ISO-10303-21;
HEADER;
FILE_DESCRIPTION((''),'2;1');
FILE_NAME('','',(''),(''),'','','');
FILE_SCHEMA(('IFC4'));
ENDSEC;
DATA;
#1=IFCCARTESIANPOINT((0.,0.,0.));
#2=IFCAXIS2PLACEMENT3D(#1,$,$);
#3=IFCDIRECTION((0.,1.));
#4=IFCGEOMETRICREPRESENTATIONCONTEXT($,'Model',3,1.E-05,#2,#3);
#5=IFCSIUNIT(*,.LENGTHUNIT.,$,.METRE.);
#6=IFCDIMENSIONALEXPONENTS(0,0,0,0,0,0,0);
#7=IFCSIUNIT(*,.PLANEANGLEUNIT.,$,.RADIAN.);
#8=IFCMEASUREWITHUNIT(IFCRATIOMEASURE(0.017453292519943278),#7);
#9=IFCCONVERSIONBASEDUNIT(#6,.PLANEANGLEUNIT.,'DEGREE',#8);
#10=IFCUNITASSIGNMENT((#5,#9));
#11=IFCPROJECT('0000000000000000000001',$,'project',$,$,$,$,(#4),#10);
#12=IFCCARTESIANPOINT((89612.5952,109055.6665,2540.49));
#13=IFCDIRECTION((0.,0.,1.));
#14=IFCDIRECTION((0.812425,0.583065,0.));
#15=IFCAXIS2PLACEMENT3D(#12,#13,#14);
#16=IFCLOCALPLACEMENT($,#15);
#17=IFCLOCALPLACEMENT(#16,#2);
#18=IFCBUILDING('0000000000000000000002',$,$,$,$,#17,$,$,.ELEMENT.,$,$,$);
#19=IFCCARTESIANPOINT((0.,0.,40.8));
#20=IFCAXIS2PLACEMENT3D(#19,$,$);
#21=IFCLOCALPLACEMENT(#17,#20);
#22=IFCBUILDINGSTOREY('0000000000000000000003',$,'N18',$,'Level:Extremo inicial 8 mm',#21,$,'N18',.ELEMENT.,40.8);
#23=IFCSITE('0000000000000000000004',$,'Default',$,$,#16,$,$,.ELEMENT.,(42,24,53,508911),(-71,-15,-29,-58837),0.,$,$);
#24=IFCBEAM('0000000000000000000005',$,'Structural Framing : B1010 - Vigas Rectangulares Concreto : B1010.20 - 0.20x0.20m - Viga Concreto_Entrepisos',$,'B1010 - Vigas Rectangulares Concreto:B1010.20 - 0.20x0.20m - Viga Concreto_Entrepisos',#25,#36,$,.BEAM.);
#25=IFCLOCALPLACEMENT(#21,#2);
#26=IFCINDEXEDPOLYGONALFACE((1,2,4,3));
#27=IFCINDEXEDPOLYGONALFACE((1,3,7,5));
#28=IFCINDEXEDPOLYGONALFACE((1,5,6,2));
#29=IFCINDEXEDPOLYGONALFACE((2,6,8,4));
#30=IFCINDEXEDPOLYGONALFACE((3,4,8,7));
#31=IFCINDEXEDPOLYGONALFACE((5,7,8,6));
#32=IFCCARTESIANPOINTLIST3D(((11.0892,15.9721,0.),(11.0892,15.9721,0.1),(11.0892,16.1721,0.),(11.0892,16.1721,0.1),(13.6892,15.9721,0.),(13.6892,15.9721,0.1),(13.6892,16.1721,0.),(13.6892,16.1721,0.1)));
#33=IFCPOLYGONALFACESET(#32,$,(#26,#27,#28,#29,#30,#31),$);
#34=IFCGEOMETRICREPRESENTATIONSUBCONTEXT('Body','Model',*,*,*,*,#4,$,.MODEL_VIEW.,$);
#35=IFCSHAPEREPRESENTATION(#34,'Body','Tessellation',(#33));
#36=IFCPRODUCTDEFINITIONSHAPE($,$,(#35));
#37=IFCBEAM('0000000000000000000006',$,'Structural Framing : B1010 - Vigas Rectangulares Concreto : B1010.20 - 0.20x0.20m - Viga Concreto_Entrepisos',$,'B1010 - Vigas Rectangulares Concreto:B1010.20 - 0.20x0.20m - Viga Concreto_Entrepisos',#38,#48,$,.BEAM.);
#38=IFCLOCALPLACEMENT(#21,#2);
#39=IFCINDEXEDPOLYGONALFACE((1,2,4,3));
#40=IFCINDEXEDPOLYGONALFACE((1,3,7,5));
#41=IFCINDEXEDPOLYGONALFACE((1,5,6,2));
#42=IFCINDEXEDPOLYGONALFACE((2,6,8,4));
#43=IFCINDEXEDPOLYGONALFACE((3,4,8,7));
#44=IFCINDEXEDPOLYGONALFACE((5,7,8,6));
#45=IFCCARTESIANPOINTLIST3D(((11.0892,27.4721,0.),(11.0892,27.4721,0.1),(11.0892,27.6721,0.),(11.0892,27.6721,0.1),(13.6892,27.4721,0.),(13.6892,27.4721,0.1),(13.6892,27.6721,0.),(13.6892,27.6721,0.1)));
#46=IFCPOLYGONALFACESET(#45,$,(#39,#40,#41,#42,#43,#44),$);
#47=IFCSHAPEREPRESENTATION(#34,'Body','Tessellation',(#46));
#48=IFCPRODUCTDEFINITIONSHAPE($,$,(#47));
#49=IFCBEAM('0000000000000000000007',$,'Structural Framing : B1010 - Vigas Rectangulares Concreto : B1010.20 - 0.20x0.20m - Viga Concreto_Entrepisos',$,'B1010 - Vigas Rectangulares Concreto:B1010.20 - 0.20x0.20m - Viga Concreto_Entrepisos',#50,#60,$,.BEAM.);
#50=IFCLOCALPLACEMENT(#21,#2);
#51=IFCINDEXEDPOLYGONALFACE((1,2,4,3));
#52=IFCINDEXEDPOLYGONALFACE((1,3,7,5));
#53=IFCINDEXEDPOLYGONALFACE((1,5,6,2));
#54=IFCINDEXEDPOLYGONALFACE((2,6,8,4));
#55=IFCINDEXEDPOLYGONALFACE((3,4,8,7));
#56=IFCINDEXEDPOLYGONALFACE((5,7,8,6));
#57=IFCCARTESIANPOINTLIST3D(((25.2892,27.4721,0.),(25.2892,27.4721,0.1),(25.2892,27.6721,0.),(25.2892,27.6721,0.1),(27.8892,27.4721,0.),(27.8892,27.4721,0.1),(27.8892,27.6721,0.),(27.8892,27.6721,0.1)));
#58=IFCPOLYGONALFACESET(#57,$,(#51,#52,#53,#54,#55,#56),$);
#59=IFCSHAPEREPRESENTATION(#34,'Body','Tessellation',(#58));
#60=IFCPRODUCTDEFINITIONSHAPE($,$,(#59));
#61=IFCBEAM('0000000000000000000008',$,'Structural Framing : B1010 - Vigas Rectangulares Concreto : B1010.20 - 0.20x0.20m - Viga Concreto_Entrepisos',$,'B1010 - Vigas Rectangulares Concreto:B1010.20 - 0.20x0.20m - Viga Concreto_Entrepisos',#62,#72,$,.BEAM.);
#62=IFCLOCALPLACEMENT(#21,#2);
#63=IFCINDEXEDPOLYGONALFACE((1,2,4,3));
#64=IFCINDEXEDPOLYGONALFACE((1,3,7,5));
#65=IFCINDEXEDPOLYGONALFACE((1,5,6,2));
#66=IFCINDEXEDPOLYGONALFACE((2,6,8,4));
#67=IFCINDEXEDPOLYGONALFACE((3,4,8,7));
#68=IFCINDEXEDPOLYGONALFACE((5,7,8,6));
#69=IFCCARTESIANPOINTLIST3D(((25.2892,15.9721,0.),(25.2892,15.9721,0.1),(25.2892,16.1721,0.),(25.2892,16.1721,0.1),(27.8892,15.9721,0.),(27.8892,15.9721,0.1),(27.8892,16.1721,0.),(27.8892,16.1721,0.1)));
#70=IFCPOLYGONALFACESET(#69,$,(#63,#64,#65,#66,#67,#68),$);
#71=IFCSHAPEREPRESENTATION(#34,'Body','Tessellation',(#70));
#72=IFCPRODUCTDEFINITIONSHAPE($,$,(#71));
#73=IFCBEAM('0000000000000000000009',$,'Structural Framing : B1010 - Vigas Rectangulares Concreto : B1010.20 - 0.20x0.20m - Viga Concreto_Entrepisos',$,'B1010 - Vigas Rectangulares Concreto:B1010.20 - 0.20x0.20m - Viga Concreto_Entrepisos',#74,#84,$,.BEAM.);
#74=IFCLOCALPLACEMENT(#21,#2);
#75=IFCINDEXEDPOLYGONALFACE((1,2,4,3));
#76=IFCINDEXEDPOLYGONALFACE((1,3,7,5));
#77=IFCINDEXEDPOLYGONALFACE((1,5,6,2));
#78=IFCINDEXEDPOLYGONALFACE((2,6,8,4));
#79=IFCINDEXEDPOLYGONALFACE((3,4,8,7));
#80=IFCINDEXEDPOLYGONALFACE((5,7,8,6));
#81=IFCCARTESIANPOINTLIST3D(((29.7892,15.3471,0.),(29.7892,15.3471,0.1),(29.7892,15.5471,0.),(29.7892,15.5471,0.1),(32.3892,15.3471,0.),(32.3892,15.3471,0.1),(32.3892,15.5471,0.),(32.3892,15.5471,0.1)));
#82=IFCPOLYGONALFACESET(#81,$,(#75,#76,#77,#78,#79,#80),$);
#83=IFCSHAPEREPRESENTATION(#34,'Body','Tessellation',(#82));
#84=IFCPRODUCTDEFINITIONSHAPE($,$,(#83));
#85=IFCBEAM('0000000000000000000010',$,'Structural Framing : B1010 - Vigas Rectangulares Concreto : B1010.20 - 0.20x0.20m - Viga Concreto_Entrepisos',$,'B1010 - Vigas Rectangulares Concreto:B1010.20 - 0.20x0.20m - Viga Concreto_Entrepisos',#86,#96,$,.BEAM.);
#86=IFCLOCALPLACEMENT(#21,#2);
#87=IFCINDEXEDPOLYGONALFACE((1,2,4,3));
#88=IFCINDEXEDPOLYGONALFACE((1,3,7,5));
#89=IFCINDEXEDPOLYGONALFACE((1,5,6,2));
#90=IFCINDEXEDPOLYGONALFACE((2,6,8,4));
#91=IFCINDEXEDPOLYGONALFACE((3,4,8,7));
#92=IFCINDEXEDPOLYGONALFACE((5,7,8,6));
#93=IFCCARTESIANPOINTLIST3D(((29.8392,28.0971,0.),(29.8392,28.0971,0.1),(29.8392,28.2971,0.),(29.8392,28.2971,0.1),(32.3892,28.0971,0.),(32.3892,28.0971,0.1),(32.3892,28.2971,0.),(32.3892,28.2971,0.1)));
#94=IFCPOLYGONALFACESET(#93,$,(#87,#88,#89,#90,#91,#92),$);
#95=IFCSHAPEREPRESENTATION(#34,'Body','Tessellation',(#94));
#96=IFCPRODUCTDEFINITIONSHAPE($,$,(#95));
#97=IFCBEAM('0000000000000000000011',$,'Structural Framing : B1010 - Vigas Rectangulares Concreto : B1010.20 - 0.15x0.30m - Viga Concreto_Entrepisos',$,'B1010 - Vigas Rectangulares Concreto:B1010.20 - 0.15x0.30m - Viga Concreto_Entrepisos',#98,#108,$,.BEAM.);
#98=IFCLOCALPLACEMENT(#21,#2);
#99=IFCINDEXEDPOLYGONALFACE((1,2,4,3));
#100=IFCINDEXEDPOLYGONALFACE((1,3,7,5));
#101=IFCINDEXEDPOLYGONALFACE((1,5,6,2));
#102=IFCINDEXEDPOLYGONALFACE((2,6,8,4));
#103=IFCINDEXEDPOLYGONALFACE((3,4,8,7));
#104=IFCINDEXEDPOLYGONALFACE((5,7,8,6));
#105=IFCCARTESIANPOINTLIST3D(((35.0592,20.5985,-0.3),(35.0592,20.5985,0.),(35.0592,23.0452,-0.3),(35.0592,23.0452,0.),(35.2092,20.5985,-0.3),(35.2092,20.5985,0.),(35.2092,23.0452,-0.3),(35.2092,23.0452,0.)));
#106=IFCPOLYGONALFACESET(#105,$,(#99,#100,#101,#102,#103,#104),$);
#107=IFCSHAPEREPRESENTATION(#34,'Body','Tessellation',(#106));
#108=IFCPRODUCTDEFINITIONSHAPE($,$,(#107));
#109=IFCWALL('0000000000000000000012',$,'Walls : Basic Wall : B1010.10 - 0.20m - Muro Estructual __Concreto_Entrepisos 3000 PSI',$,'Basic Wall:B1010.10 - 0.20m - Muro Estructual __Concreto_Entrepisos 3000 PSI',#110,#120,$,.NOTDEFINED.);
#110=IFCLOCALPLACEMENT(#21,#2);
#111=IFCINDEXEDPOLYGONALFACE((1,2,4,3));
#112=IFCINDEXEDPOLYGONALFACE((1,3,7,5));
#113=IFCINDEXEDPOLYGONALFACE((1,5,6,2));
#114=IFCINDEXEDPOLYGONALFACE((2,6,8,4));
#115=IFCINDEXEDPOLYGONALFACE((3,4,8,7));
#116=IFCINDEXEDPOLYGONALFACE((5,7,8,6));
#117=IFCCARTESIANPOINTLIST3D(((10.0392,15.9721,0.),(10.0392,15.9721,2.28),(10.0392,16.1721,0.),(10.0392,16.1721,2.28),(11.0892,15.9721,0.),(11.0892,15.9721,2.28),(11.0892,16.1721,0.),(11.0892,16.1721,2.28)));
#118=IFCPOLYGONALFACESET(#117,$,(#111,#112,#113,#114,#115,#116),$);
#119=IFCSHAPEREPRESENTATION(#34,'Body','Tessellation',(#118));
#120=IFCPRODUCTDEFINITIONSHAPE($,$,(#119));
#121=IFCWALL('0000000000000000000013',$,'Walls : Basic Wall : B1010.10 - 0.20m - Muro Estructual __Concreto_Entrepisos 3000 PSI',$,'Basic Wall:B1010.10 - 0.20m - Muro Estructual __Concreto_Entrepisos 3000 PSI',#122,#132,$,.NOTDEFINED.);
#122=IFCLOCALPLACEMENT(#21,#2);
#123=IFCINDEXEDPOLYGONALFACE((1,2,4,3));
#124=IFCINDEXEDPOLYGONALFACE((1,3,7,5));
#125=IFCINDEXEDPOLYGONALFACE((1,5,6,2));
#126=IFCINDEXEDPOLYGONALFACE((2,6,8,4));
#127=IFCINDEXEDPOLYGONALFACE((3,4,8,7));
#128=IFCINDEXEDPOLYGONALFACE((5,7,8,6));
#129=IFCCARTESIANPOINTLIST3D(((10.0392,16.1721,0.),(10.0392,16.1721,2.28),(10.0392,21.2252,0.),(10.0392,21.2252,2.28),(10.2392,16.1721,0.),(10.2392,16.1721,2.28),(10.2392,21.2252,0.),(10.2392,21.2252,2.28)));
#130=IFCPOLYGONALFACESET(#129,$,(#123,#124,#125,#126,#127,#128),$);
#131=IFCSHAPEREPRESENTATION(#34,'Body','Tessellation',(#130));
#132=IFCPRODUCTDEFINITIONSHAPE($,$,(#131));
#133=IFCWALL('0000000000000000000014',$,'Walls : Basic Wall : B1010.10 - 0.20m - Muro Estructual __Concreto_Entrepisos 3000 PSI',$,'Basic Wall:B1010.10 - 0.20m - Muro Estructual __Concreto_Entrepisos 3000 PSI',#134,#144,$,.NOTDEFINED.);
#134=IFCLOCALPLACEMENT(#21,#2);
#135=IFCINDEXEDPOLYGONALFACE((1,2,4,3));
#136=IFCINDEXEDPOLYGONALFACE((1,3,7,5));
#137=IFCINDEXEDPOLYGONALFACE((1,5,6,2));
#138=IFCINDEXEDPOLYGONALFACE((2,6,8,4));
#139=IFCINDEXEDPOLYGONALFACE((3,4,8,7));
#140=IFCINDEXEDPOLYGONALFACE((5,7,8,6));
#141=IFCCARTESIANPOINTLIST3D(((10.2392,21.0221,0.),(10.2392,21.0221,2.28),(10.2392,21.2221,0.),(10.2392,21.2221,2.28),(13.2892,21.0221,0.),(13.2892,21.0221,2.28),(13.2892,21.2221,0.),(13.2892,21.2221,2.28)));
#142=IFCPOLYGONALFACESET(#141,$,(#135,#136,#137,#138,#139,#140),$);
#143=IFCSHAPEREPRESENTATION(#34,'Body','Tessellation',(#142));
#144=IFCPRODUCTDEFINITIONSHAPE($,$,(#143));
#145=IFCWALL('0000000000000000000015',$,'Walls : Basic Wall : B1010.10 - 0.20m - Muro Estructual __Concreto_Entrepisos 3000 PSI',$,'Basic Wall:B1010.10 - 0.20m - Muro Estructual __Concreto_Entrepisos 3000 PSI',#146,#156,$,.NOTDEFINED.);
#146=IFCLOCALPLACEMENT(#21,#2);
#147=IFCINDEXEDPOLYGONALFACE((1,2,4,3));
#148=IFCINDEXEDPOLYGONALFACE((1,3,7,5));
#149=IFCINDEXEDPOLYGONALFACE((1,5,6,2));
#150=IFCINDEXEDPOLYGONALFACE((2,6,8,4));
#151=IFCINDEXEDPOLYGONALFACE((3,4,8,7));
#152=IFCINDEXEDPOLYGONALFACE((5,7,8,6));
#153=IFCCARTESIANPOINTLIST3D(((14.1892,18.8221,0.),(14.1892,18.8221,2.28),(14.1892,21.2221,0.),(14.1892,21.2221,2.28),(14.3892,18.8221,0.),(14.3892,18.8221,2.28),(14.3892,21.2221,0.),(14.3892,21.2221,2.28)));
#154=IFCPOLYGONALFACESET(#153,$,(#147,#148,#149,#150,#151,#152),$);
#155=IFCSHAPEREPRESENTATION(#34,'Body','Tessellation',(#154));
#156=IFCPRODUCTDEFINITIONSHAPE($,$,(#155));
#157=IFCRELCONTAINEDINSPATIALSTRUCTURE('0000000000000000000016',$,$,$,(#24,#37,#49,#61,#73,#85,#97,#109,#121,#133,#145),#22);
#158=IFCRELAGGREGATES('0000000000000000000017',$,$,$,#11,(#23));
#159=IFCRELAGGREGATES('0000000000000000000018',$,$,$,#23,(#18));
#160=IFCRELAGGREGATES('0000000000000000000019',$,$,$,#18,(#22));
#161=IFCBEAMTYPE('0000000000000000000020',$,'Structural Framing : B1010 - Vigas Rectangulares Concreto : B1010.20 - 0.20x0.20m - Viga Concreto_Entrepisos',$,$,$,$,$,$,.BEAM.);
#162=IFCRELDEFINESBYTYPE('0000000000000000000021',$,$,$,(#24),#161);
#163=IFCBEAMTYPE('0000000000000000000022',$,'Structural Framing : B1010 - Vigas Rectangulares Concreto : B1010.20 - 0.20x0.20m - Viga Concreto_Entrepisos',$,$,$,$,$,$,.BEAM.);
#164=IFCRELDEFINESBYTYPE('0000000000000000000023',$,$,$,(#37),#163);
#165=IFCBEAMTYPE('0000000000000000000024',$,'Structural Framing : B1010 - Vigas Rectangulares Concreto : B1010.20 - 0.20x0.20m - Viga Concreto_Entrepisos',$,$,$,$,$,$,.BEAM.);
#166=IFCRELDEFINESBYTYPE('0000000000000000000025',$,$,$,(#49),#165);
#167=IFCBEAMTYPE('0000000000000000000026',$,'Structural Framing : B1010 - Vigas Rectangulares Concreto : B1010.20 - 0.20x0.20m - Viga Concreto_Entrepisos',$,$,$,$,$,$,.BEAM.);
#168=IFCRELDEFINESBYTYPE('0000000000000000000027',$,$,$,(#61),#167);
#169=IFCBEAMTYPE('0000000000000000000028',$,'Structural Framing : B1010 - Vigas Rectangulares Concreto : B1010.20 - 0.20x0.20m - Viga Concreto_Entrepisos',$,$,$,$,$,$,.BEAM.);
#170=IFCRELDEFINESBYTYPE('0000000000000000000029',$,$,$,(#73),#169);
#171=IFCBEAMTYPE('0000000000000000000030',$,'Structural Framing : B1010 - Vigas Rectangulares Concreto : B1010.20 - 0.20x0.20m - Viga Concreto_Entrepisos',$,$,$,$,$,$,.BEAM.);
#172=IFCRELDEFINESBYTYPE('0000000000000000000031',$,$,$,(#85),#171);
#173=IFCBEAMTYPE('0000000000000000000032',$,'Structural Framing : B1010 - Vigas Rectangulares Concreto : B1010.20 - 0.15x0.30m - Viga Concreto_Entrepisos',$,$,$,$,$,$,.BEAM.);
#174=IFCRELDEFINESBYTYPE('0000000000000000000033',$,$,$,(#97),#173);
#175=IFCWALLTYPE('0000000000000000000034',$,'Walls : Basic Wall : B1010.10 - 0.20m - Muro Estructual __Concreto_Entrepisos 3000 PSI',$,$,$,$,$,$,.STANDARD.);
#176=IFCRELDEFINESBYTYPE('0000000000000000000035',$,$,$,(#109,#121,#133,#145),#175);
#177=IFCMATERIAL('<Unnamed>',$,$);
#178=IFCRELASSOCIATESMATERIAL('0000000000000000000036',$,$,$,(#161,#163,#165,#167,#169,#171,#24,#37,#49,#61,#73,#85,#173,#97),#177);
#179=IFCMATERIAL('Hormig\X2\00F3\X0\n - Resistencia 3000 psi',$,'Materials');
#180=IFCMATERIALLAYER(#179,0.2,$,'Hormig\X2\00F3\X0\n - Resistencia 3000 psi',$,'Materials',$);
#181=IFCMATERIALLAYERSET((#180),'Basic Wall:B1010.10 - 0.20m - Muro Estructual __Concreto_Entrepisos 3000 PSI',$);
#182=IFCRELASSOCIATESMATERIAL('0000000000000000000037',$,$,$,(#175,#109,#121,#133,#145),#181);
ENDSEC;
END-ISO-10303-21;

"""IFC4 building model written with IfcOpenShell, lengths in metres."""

from ifc_helpers import new_model, entity, si_unit, converted_unit, direction, frame, frame_2d, origin, place, context, subcontext, project, spatial, polyline, segment, composite_curve, rectangle, outline, extrude, source, transform, mapped, material, layer, layer_set, layer_usage, material_profile, profile_set, profile_usage, type_object, type_shapes, element, save


model = new_model("IFC4")

# Units and contexts
model_context = context("Model", 3, precision=1e-05, world=origin(), true_north=direction((0.0, 1.0)))
body_context = subcontext(model_context, "Body", "Model", "MODEL_VIEW")
ifc_project = project(units=[si_unit("LENGTHUNIT", "METRE"), converted_unit("PLANEANGLEUNIT", "DEGREE", entity("IfcRatioMeasure", 0.017453292519943278), si_unit("PLANEANGLEUNIT", "RADIAN"), dimensions=[0, 0, 0, 0, 0, 0, 0])], contexts=[model_context])

# Site, building, storey
site_placement = place(None, frame((89612.5952, 109055.6665, 2540.49), z_axis=(0.0, 0.0, 1.0), x_axis=(0.812425, 0.583065, 0.0)))
site = spatial("IfcSite", under=ifc_project, at=site_placement, Name="Default", CompositionType="ELEMENT", RefLatitude=(42, 24, 53, 508911), RefLongitude=(-71, -15, -29, -58837), RefElevation=0.0)
building_placement = place(site_placement, origin())
building = spatial("IfcBuilding", under=site, at=building_placement, CompositionType="ELEMENT")
storey_placement = place(building_placement, frame((0.0, 0.0, 40.8)))
storey = spatial("IfcBuildingStorey", under=building, at=storey_placement, Name="N18", ObjectType="Level:Extremo inicial 8 mm", LongName="N18", CompositionType="ELEMENT", Elevation=40.8)

# Beams
ifc_material_1 = material(Name="<Unnamed>")
ifc_material_profile_1 = material_profile(ifc_material_1, outline(composite_curve([segment(polyline([(-0.1, 0.0, 0.0), (-0.1, 0.1, 0.0)]), True, "CONTINUOUS"), segment(polyline([(-0.1, 0.1, 0.0), (0.1, 0.1, 0.0)]), True, "CONTINUOUS"), segment(polyline([(0.1, 0.1, 0.0), (0.1, 0.0, 0.0)]), True, "CONTINUOUS"), segment(polyline([(0.1, 0.0, 0.0), (-0.1, 0.0, 0.0)]), True, "CONTINUOUS")], self_intersect=False), kind="CURVE"), Name="B1010.20 - 0.20x0.20m - Viga Concreto_Entrepisos")
ifc_material_profile_2 = material_profile(ifc_material_1, outline(composite_curve([segment(polyline([(-1.3, -0.1, 0.1), (-1.3, 0.1, 0.1)]), True, "CONTINUOUS"), segment(polyline([(-1.3, 0.1, 0.1), (-1.3, 0.1, -0.1)]), True, "CONTINUOUS"), segment(polyline([(-1.3, 0.1, -0.1), (-1.3, -0.1, -0.1)]), True, "CONTINUOUS"), segment(polyline([(-1.3, -0.1, -0.1), (-1.3, -0.1, 0.1)]), True, "CONTINUOUS")], self_intersect=False), kind="CURVE"), Name="B1010.20 - 0.20x0.20m - Viga Concreto_Entrepisos")
ifc_profile_set_1 = profile_set([ifc_material_profile_1, ifc_material_profile_2], Name="B1010.20 - 0.20x0.20m - Viga Concreto_Entrepisos")
ifc_profile_usage_1 = profile_usage(ifc_profile_set_1, cardinal=8)
beam_type_1 = type_object("IfcBeamType", Name="Structural Framing : B1010 - Vigas Rectangulares Concreto : B1010.20 - 0.20x0.20m - Viga Concreto_Entrepisos", PredefinedType="BEAM", material=ifc_profile_set_1)
shared_shape_1 = source(origin(), body_context, "Body", "SweptSolid", [
    extrude(rectangle(XDim=0.1, YDim=0.2, at=frame_2d((0.0, 0.0), x_axis=(1.0, 0.0))), frame((13.6892, 16.0721, 40.85), z_axis=(-1.0, 0.0, 0.0), x_axis=(0.0, 0.0, -1.0)), (0.0, 0.0, 1.0), 2.6),
])
type_shapes(beam_type_1, [shared_shape_1])
beam_1_placement = place(storey_placement, frame((0.0, 0.0, -40.8)))
element("IfcBeam", 1, at=beam_1_placement, inside=storey, type_object=beam_type_1, material=ifc_profile_usage_1, Name="Structural Framing : B1010 - Vigas Rectangulares Concreto : B1010.20 - 0.20x0.20m - Viga Concreto_Entrepisos", ObjectType="B1010 - Vigas Rectangulares Concreto:B1010.20 - 0.20x0.20m - Viga Concreto_Entrepisos", PredefinedType="BEAM", context=body_context, shape_type="MappedRepresentation", body=[
    mapped(shared_shape_1, transform((0.0, 0.0, 0.0), scale=1.0)),
])
ifc_profile_usage_2 = profile_usage(ifc_profile_set_1, cardinal=8)
beam_type_2 = type_object("IfcBeamType", Name="Structural Framing : B1010 - Vigas Rectangulares Concreto : B1010.20 - 0.20x0.20m - Viga Concreto_Entrepisos", PredefinedType="BEAM", material=ifc_profile_set_1)
shared_shape_2 = source(origin(), body_context, "Body", "SweptSolid", [
    extrude(rectangle(XDim=0.1, YDim=0.2, at=frame_2d((0.0, 0.0), x_axis=(1.0, 0.0))), frame((13.6892, 27.5721, 40.85), z_axis=(-1.0, 0.0, 0.0), x_axis=(0.0, 0.0, -1.0)), (0.0, 0.0, 1.0), 2.6),
])
type_shapes(beam_type_2, [shared_shape_2])
beam_2_placement = place(storey_placement, frame((0.0, 0.0, -40.8)))
element("IfcBeam", 2, at=beam_2_placement, inside=storey, type_object=beam_type_2, material=ifc_profile_usage_2, Name="Structural Framing : B1010 - Vigas Rectangulares Concreto : B1010.20 - 0.20x0.20m - Viga Concreto_Entrepisos", ObjectType="B1010 - Vigas Rectangulares Concreto:B1010.20 - 0.20x0.20m - Viga Concreto_Entrepisos", PredefinedType="BEAM", context=body_context, shape_type="MappedRepresentation", body=[
    mapped(shared_shape_2, transform((0.0, 0.0, 0.0), scale=1.0)),
])
ifc_profile_usage_3 = profile_usage(ifc_profile_set_1, cardinal=8)
beam_type_3 = type_object("IfcBeamType", Name="Structural Framing : B1010 - Vigas Rectangulares Concreto : B1010.20 - 0.20x0.20m - Viga Concreto_Entrepisos", PredefinedType="BEAM", material=ifc_profile_set_1)
shared_shape_3 = source(origin(), body_context, "Body", "SweptSolid", [
    extrude(rectangle(XDim=0.1, YDim=0.2, at=frame_2d((0.0, 0.0), x_axis=(1.0, 0.0))), frame((25.2892, 27.5721, 40.85), z_axis=(1.0, 0.0, 0.0), x_axis=(0.0, 0.0, -1.0)), (0.0, 0.0, 1.0), 2.6),
])
type_shapes(beam_type_3, [shared_shape_3])
beam_3_placement = place(storey_placement, frame((0.0, 0.0, -40.8)))
element("IfcBeam", 3, at=beam_3_placement, inside=storey, type_object=beam_type_3, material=ifc_profile_usage_3, Name="Structural Framing : B1010 - Vigas Rectangulares Concreto : B1010.20 - 0.20x0.20m - Viga Concreto_Entrepisos", ObjectType="B1010 - Vigas Rectangulares Concreto:B1010.20 - 0.20x0.20m - Viga Concreto_Entrepisos", PredefinedType="BEAM", context=body_context, shape_type="MappedRepresentation", body=[
    mapped(shared_shape_3, transform((0.0, 0.0, 0.0), scale=1.0)),
])
ifc_profile_usage_4 = profile_usage(ifc_profile_set_1, cardinal=8)
beam_type_4 = type_object("IfcBeamType", Name="Structural Framing : B1010 - Vigas Rectangulares Concreto : B1010.20 - 0.20x0.20m - Viga Concreto_Entrepisos", PredefinedType="BEAM", material=ifc_profile_set_1)
shared_shape_4 = source(origin(), body_context, "Body", "SweptSolid", [
    extrude(rectangle(XDim=0.1, YDim=0.2, at=frame_2d((0.0, 0.0), x_axis=(1.0, 0.0))), frame((25.2892, 16.0721, 40.85), z_axis=(1.0, 0.0, 0.0), x_axis=(0.0, 0.0, -1.0)), (0.0, 0.0, 1.0), 2.6),
])
type_shapes(beam_type_4, [shared_shape_4])
beam_4_placement = place(storey_placement, frame((0.0, 0.0, -40.8)))
element("IfcBeam", 4, at=beam_4_placement, inside=storey, type_object=beam_type_4, material=ifc_profile_usage_4, Name="Structural Framing : B1010 - Vigas Rectangulares Concreto : B1010.20 - 0.20x0.20m - Viga Concreto_Entrepisos", ObjectType="B1010 - Vigas Rectangulares Concreto:B1010.20 - 0.20x0.20m - Viga Concreto_Entrepisos", PredefinedType="BEAM", context=body_context, shape_type="MappedRepresentation", body=[
    mapped(shared_shape_4, transform((0.0, 0.0, 0.0), scale=1.0)),
])
ifc_profile_usage_5 = profile_usage(ifc_profile_set_1, cardinal=8)
beam_type_5 = type_object("IfcBeamType", Name="Structural Framing : B1010 - Vigas Rectangulares Concreto : B1010.20 - 0.20x0.20m - Viga Concreto_Entrepisos", PredefinedType="BEAM", material=ifc_profile_set_1)
shared_shape_5 = source(origin(), body_context, "Body", "SweptSolid", [
    extrude(rectangle(XDim=0.1, YDim=0.2, at=frame_2d((0.0, 0.0), x_axis=(1.0, 0.0))), frame((32.3892, 15.4471, 40.85), z_axis=(-1.0, 0.0, 0.0), x_axis=(0.0, 0.0, -1.0)), (0.0, 0.0, 1.0), 2.6),
])
type_shapes(beam_type_5, [shared_shape_5])
beam_5_placement = place(storey_placement, frame((0.0, 0.0, -40.8)))
element("IfcBeam", 5, at=beam_5_placement, inside=storey, type_object=beam_type_5, material=ifc_profile_usage_5, Name="Structural Framing : B1010 - Vigas Rectangulares Concreto : B1010.20 - 0.20x0.20m - Viga Concreto_Entrepisos", ObjectType="B1010 - Vigas Rectangulares Concreto:B1010.20 - 0.20x0.20m - Viga Concreto_Entrepisos", PredefinedType="BEAM", context=body_context, shape_type="MappedRepresentation", body=[
    mapped(shared_shape_5, transform((0.0, 0.0, 0.0), scale=1.0)),
])
ifc_profile_usage_6 = profile_usage(ifc_profile_set_1, cardinal=8)
beam_type_6 = type_object("IfcBeamType", Name="Structural Framing : B1010 - Vigas Rectangulares Concreto : B1010.20 - 0.20x0.20m - Viga Concreto_Entrepisos", PredefinedType="BEAM", material=ifc_profile_set_1)
shared_shape_6 = source(origin(), body_context, "Body", "SweptSolid", [
    extrude(rectangle(XDim=0.1, YDim=0.2, at=frame_2d((0.0, 0.0), x_axis=(1.0, 0.0))), frame((29.8392, 28.1971, 40.85), z_axis=(1.0, 0.0, 0.0), x_axis=(0.0, 0.0, -1.0)), (0.0, 0.0, 1.0), 2.55),
])
type_shapes(beam_type_6, [shared_shape_6])
beam_6_placement = place(storey_placement, frame((0.0, 0.0, -40.8)))
element("IfcBeam", 6, at=beam_6_placement, inside=storey, type_object=beam_type_6, material=ifc_profile_usage_6, Name="Structural Framing : B1010 - Vigas Rectangulares Concreto : B1010.20 - 0.20x0.20m - Viga Concreto_Entrepisos", ObjectType="B1010 - Vigas Rectangulares Concreto:B1010.20 - 0.20x0.20m - Viga Concreto_Entrepisos", PredefinedType="BEAM", context=body_context, shape_type="MappedRepresentation", body=[
    mapped(shared_shape_6, transform((0.0, 0.0, 0.0), scale=1.0)),
])
ifc_material_profile_3 = material_profile(ifc_material_1, outline(composite_curve([segment(polyline([(-0.075, -0.15, 0.0), (-0.075, 0.15, 0.0)]), True, "CONTINUOUS"), segment(polyline([(-0.075, 0.15, 0.0), (0.075, 0.15, 0.0)]), True, "CONTINUOUS"), segment(polyline([(0.075, 0.15, 0.0), (0.075, -0.15, 0.0)]), True, "CONTINUOUS"), segment(polyline([(0.075, -0.15, 0.0), (-0.075, -0.15, 0.0)]), True, "CONTINUOUS")], self_intersect=False), kind="CURVE"), Name="B1010.20 - 0.15x0.30m - Viga Concreto_Entrepisos")
ifc_material_profile_4 = material_profile(ifc_material_1, outline(composite_curve([segment(polyline([(1.2233, 0.075, 0.15), (1.2233, 0.075, -0.15)]), True, "CONTINUOUS"), segment(polyline([(1.2233, 0.075, -0.15), (-1.2233, 0.075, -0.15)]), True, "CONTINUOUS"), segment(polyline([(-1.2233, 0.075, -0.15), (-1.2233, 0.075, 0.15)]), True, "CONTINUOUS"), segment(polyline([(-1.2233, 0.075, 0.15), (1.2233, 0.075, 0.15)]), True, "CONTINUOUS")], self_intersect=False), kind="CURVE"), Name="B1010.20 - 0.15x0.30m - Viga Concreto_Entrepisos")
ifc_profile_set_2 = profile_set([ifc_material_profile_3, ifc_material_profile_4], Name="B1010.20 - 0.15x0.30m - Viga Concreto_Entrepisos")
ifc_profile_usage_7 = profile_usage(ifc_profile_set_2, cardinal=8)
beam_type_7 = type_object("IfcBeamType", Name="Structural Framing : B1010 - Vigas Rectangulares Concreto : B1010.20 - 0.15x0.30m - Viga Concreto_Entrepisos", PredefinedType="BEAM", material=ifc_profile_set_2)
shared_shape_7 = source(origin(), body_context, "Body", "SweptSolid", [
    extrude(rectangle(XDim=0.3, YDim=0.15, at=frame_2d((0.0, 0.0), x_axis=(0.0, 1.0))), frame((35.1342, 20.5985, 40.65), z_axis=(0.0, 1.0, 0.0), x_axis=(-1.0, 0.0, 0.0)), (0.0, 0.0, 1.0), 2.4467),
])
type_shapes(beam_type_7, [shared_shape_7])
beam_7_placement = place(storey_placement, frame((0.0, 0.0, -40.8)))
element("IfcBeam", 7, at=beam_7_placement, inside=storey, type_object=beam_type_7, material=ifc_profile_usage_7, Name="Structural Framing : B1010 - Vigas Rectangulares Concreto : B1010.20 - 0.15x0.30m - Viga Concreto_Entrepisos", ObjectType="B1010 - Vigas Rectangulares Concreto:B1010.20 - 0.15x0.30m - Viga Concreto_Entrepisos", PredefinedType="BEAM", context=body_context, shape_type="MappedRepresentation", body=[
    mapped(shared_shape_7, transform((0.0, 0.0, 0.0), scale=1.0)),
])

# Walls
ifc_material_2 = material(Name="Hormigón - Resistencia 3000 psi", Category="Materials")
ifc_layer_1 = layer(ifc_material_2, 0.2, Name="Hormigón - Resistencia 3000 psi", Category="Materials")
ifc_layer_set_1 = layer_set([ifc_layer_1], Name="Basic Wall:B1010.10 - 0.20m - Muro Estructual __Concreto_Entrepisos 3000 PSI")
ifc_layer_usage_1 = layer_usage(ifc_layer_set_1, "AXIS2", "NEGATIVE", 0.1)
wall_type_1 = type_object("IfcWallType", Name="Walls : Basic Wall : B1010.10 - 0.20m - Muro Estructual __Concreto_Entrepisos 3000 PSI", PredefinedType="STANDARD", material=ifc_layer_set_1)
wall_1_placement = place(storey_placement, frame((11.0892, 16.0721, 0.0), z_axis=(0.0, 0.0, 1.0), x_axis=(-1.0, 0.0, 0.0)))
element("IfcWall", 8, at=wall_1_placement, inside=storey, type_object=wall_type_1, material=ifc_layer_usage_1, Name="Walls : Basic Wall : B1010.10 - 0.20m - Muro Estructual __Concreto_Entrepisos 3000 PSI", ObjectType="Basic Wall:B1010.10 - 0.20m - Muro Estructual __Concreto_Entrepisos 3000 PSI", PredefinedType="NOTDEFINED", context=body_context, shape_type="SweptSolid", body=[
    extrude(rectangle(XDim=1.05, YDim=0.2, at=frame_2d((0.525, 0.0), x_axis=(-1.0, 0.0))), origin(), (0.0, 0.0, 1.0), 2.28),
])
ifc_layer_usage_2 = layer_usage(ifc_layer_set_1, "AXIS2", "NEGATIVE", 0.1)
wall_2_placement = place(storey_placement, frame((10.1392, 16.1721, 0.0), z_axis=(0.0, 0.0, 1.0), x_axis=(0.0, 1.0, 0.0)))
element("IfcWall", 9, at=wall_2_placement, inside=storey, type_object=wall_type_1, material=ifc_layer_usage_2, Name="Walls : Basic Wall : B1010.10 - 0.20m - Muro Estructual __Concreto_Entrepisos 3000 PSI", ObjectType="Basic Wall:B1010.10 - 0.20m - Muro Estructual __Concreto_Entrepisos 3000 PSI", PredefinedType="NOTDEFINED", context=body_context, shape_type="SweptSolid", body=[
    extrude(rectangle(XDim=5.0531, YDim=0.2, at=frame_2d((2.5265, 0.0), x_axis=(-1.0, 0.0))), origin(), (0.0, 0.0, 1.0), 2.28),
])
ifc_layer_usage_3 = layer_usage(ifc_layer_set_1, "AXIS2", "NEGATIVE", 0.1)
wall_3_placement = place(storey_placement, frame((10.2392, 21.1221, 0.0)))
element("IfcWall", 10, at=wall_3_placement, inside=storey, type_object=wall_type_1, material=ifc_layer_usage_3, Name="Walls : Basic Wall : B1010.10 - 0.20m - Muro Estructual __Concreto_Entrepisos 3000 PSI", ObjectType="Basic Wall:B1010.10 - 0.20m - Muro Estructual __Concreto_Entrepisos 3000 PSI", PredefinedType="NOTDEFINED", context=body_context, shape_type="SweptSolid", body=[
    extrude(rectangle(XDim=3.05, YDim=0.2, at=frame_2d((1.525, 0.0), x_axis=(-1.0, 0.0))), origin(), (0.0, 0.0, 1.0), 2.28),
])
ifc_layer_usage_4 = layer_usage(ifc_layer_set_1, "AXIS2", "NEGATIVE", 0.1)
wall_4_placement = place(storey_placement, frame((14.2892, 18.8221, 0.0), z_axis=(0.0, 0.0, 1.0), x_axis=(0.0, 1.0, 0.0)))
element("IfcWall", 11, at=wall_4_placement, inside=storey, type_object=wall_type_1, material=ifc_layer_usage_4, Name="Walls : Basic Wall : B1010.10 - 0.20m - Muro Estructual __Concreto_Entrepisos 3000 PSI", ObjectType="Basic Wall:B1010.10 - 0.20m - Muro Estructual __Concreto_Entrepisos 3000 PSI", PredefinedType="NOTDEFINED", context=body_context, shape_type="SweptSolid", body=[
    extrude(rectangle(XDim=2.4, YDim=0.2, at=frame_2d((1.2, 0.0), x_axis=(-1.0, 0.0))), origin(), (0.0, 0.0, 1.0), 2.28),
])

save(model, "model.ifc")
